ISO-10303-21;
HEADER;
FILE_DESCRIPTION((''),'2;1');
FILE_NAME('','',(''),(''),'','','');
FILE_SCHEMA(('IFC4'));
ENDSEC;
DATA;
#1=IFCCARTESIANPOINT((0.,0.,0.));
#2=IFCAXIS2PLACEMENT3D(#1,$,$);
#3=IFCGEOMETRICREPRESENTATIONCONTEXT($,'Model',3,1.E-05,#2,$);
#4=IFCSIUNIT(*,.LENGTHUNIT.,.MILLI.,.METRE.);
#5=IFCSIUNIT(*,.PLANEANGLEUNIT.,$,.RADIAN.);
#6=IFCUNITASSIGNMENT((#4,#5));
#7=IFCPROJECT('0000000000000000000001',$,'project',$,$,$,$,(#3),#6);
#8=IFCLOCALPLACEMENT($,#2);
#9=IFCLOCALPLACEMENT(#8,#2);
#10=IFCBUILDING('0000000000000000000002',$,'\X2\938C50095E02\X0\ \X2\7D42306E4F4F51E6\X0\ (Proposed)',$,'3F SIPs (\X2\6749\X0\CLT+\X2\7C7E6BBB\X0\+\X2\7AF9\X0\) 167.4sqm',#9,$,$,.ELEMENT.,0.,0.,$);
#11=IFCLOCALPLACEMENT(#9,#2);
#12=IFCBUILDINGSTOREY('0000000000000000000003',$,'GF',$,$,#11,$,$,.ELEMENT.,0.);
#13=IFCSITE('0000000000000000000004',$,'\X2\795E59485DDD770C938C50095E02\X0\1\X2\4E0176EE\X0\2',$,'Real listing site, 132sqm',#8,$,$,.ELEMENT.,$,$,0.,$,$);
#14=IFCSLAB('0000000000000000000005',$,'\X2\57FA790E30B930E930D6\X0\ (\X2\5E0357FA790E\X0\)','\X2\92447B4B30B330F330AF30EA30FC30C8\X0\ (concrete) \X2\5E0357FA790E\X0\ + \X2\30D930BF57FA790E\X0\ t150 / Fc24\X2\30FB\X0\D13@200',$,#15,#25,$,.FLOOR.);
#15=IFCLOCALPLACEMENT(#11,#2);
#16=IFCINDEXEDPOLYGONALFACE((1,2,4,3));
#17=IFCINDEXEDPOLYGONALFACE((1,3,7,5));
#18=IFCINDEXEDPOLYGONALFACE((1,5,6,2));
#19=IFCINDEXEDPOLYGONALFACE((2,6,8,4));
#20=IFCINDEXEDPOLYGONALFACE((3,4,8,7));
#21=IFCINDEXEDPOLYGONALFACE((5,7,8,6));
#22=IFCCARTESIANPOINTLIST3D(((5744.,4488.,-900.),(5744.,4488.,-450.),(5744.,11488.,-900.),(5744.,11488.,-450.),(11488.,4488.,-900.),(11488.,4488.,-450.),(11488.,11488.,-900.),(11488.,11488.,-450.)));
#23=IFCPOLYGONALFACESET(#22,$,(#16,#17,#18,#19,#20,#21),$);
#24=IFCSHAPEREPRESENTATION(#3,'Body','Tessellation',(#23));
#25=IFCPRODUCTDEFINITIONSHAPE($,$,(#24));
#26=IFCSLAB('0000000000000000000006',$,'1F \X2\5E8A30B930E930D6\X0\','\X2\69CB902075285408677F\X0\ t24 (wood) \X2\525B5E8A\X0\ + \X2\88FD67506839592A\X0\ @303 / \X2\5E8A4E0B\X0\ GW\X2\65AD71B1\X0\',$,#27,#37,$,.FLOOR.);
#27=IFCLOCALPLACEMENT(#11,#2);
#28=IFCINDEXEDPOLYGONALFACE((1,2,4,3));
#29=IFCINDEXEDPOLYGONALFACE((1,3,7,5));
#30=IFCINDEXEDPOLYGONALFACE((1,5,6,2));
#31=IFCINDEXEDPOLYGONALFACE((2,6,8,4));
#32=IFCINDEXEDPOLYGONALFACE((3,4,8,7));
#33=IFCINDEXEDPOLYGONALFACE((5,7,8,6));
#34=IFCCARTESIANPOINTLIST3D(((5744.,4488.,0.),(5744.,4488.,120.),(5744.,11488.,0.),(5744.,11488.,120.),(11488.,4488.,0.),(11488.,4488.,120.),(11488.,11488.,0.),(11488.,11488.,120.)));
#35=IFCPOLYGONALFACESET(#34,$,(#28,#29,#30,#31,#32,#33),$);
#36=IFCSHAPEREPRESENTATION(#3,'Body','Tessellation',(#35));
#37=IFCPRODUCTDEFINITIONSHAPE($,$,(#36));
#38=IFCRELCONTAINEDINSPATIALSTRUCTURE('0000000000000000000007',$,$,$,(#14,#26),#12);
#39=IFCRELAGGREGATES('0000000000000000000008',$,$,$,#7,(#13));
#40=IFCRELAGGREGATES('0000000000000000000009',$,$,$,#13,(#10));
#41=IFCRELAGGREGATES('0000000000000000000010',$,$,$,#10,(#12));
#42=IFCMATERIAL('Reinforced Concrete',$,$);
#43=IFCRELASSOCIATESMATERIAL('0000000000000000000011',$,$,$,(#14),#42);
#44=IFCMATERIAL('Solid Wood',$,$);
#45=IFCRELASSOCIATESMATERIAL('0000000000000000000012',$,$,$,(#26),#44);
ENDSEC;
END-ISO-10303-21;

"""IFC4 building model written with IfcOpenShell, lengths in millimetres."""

from ifc_helpers import new_model, si_unit, frame, frame_2d, origin, place, context, project, spatial, rectangle, extrude, material, element, save


model = new_model("IFC4")

# Units and contexts
model_context = context("Model", 3, precision=1e-05, world=origin())
ifc_project = project(units=[si_unit("LENGTHUNIT", "METRE", prefix="MILLI"), si_unit("PLANEANGLEUNIT", "RADIAN")], contexts=[model_context])

# Site, building, storey
site_placement = place(None, origin())
site = spatial("IfcSite", under=ifc_project, at=site_placement, Name="神奈川県鎌倉市1丁目2", ObjectType="Real listing site, 132sqm", CompositionType="ELEMENT", RefElevation=0.0)
building_placement = place(site_placement, origin())
building = spatial("IfcBuilding", under=site, at=building_placement, Name="鎌倉市 終の住処 (Proposed)", ObjectType="3F SIPs (杉CLT+籾殻+竹) 167.4sqm", CompositionType="ELEMENT", ElevationOfRefHeight=0.0, ElevationOfTerrain=0.0)
storey_placement = place(building_placement, origin())
storey = spatial("IfcBuildingStorey", under=building, at=storey_placement, Name="GF", CompositionType="ELEMENT", Elevation=0.0)

# Slabs
ifc_material_1 = material(Name="Reinforced Concrete")
slab_1_placement = place(storey_placement, frame((2872.0, 2244.0, -450.0)))
element("IfcSlab", 1, at=slab_1_placement, inside=storey, material=ifc_material_1, Name="基礎スラブ (布基礎)", Description="鉄筋コンクリート (concrete) 布基礎 + ベタ基礎 t150 / Fc24・D13@200", PredefinedType="FLOOR", context=model_context, shape_type="SweptSolid", body=[
    extrude(rectangle(XDim=5744.0, YDim=7000.0, at=frame_2d((2872.0, 3500.0))), frame((2872.0, 2244.0, -450.0)), (0.0, 0.0, 1.0), 450.0),
])
ifc_material_2 = material(Name="Solid Wood")
slab_2_placement = place(storey_placement, frame((2872.0, 2244.0, 0.0)))
element("IfcSlab", 2, at=slab_2_placement, inside=storey, material=ifc_material_2, Name="1F 床スラブ", Description="構造用合板 t24 (wood) 剛床 + 製材根太 @303 / 床下 GW断熱", PredefinedType="FLOOR", context=model_context, shape_type="SweptSolid", body=[
    extrude(rectangle(XDim=5744.0, YDim=7000.0, at=frame_2d((2872.0, 3500.0))), frame((2872.0, 2244.0, 0.0)), (0.0, 0.0, 1.0), 120.0),
])

save(model, "model.ifc")
